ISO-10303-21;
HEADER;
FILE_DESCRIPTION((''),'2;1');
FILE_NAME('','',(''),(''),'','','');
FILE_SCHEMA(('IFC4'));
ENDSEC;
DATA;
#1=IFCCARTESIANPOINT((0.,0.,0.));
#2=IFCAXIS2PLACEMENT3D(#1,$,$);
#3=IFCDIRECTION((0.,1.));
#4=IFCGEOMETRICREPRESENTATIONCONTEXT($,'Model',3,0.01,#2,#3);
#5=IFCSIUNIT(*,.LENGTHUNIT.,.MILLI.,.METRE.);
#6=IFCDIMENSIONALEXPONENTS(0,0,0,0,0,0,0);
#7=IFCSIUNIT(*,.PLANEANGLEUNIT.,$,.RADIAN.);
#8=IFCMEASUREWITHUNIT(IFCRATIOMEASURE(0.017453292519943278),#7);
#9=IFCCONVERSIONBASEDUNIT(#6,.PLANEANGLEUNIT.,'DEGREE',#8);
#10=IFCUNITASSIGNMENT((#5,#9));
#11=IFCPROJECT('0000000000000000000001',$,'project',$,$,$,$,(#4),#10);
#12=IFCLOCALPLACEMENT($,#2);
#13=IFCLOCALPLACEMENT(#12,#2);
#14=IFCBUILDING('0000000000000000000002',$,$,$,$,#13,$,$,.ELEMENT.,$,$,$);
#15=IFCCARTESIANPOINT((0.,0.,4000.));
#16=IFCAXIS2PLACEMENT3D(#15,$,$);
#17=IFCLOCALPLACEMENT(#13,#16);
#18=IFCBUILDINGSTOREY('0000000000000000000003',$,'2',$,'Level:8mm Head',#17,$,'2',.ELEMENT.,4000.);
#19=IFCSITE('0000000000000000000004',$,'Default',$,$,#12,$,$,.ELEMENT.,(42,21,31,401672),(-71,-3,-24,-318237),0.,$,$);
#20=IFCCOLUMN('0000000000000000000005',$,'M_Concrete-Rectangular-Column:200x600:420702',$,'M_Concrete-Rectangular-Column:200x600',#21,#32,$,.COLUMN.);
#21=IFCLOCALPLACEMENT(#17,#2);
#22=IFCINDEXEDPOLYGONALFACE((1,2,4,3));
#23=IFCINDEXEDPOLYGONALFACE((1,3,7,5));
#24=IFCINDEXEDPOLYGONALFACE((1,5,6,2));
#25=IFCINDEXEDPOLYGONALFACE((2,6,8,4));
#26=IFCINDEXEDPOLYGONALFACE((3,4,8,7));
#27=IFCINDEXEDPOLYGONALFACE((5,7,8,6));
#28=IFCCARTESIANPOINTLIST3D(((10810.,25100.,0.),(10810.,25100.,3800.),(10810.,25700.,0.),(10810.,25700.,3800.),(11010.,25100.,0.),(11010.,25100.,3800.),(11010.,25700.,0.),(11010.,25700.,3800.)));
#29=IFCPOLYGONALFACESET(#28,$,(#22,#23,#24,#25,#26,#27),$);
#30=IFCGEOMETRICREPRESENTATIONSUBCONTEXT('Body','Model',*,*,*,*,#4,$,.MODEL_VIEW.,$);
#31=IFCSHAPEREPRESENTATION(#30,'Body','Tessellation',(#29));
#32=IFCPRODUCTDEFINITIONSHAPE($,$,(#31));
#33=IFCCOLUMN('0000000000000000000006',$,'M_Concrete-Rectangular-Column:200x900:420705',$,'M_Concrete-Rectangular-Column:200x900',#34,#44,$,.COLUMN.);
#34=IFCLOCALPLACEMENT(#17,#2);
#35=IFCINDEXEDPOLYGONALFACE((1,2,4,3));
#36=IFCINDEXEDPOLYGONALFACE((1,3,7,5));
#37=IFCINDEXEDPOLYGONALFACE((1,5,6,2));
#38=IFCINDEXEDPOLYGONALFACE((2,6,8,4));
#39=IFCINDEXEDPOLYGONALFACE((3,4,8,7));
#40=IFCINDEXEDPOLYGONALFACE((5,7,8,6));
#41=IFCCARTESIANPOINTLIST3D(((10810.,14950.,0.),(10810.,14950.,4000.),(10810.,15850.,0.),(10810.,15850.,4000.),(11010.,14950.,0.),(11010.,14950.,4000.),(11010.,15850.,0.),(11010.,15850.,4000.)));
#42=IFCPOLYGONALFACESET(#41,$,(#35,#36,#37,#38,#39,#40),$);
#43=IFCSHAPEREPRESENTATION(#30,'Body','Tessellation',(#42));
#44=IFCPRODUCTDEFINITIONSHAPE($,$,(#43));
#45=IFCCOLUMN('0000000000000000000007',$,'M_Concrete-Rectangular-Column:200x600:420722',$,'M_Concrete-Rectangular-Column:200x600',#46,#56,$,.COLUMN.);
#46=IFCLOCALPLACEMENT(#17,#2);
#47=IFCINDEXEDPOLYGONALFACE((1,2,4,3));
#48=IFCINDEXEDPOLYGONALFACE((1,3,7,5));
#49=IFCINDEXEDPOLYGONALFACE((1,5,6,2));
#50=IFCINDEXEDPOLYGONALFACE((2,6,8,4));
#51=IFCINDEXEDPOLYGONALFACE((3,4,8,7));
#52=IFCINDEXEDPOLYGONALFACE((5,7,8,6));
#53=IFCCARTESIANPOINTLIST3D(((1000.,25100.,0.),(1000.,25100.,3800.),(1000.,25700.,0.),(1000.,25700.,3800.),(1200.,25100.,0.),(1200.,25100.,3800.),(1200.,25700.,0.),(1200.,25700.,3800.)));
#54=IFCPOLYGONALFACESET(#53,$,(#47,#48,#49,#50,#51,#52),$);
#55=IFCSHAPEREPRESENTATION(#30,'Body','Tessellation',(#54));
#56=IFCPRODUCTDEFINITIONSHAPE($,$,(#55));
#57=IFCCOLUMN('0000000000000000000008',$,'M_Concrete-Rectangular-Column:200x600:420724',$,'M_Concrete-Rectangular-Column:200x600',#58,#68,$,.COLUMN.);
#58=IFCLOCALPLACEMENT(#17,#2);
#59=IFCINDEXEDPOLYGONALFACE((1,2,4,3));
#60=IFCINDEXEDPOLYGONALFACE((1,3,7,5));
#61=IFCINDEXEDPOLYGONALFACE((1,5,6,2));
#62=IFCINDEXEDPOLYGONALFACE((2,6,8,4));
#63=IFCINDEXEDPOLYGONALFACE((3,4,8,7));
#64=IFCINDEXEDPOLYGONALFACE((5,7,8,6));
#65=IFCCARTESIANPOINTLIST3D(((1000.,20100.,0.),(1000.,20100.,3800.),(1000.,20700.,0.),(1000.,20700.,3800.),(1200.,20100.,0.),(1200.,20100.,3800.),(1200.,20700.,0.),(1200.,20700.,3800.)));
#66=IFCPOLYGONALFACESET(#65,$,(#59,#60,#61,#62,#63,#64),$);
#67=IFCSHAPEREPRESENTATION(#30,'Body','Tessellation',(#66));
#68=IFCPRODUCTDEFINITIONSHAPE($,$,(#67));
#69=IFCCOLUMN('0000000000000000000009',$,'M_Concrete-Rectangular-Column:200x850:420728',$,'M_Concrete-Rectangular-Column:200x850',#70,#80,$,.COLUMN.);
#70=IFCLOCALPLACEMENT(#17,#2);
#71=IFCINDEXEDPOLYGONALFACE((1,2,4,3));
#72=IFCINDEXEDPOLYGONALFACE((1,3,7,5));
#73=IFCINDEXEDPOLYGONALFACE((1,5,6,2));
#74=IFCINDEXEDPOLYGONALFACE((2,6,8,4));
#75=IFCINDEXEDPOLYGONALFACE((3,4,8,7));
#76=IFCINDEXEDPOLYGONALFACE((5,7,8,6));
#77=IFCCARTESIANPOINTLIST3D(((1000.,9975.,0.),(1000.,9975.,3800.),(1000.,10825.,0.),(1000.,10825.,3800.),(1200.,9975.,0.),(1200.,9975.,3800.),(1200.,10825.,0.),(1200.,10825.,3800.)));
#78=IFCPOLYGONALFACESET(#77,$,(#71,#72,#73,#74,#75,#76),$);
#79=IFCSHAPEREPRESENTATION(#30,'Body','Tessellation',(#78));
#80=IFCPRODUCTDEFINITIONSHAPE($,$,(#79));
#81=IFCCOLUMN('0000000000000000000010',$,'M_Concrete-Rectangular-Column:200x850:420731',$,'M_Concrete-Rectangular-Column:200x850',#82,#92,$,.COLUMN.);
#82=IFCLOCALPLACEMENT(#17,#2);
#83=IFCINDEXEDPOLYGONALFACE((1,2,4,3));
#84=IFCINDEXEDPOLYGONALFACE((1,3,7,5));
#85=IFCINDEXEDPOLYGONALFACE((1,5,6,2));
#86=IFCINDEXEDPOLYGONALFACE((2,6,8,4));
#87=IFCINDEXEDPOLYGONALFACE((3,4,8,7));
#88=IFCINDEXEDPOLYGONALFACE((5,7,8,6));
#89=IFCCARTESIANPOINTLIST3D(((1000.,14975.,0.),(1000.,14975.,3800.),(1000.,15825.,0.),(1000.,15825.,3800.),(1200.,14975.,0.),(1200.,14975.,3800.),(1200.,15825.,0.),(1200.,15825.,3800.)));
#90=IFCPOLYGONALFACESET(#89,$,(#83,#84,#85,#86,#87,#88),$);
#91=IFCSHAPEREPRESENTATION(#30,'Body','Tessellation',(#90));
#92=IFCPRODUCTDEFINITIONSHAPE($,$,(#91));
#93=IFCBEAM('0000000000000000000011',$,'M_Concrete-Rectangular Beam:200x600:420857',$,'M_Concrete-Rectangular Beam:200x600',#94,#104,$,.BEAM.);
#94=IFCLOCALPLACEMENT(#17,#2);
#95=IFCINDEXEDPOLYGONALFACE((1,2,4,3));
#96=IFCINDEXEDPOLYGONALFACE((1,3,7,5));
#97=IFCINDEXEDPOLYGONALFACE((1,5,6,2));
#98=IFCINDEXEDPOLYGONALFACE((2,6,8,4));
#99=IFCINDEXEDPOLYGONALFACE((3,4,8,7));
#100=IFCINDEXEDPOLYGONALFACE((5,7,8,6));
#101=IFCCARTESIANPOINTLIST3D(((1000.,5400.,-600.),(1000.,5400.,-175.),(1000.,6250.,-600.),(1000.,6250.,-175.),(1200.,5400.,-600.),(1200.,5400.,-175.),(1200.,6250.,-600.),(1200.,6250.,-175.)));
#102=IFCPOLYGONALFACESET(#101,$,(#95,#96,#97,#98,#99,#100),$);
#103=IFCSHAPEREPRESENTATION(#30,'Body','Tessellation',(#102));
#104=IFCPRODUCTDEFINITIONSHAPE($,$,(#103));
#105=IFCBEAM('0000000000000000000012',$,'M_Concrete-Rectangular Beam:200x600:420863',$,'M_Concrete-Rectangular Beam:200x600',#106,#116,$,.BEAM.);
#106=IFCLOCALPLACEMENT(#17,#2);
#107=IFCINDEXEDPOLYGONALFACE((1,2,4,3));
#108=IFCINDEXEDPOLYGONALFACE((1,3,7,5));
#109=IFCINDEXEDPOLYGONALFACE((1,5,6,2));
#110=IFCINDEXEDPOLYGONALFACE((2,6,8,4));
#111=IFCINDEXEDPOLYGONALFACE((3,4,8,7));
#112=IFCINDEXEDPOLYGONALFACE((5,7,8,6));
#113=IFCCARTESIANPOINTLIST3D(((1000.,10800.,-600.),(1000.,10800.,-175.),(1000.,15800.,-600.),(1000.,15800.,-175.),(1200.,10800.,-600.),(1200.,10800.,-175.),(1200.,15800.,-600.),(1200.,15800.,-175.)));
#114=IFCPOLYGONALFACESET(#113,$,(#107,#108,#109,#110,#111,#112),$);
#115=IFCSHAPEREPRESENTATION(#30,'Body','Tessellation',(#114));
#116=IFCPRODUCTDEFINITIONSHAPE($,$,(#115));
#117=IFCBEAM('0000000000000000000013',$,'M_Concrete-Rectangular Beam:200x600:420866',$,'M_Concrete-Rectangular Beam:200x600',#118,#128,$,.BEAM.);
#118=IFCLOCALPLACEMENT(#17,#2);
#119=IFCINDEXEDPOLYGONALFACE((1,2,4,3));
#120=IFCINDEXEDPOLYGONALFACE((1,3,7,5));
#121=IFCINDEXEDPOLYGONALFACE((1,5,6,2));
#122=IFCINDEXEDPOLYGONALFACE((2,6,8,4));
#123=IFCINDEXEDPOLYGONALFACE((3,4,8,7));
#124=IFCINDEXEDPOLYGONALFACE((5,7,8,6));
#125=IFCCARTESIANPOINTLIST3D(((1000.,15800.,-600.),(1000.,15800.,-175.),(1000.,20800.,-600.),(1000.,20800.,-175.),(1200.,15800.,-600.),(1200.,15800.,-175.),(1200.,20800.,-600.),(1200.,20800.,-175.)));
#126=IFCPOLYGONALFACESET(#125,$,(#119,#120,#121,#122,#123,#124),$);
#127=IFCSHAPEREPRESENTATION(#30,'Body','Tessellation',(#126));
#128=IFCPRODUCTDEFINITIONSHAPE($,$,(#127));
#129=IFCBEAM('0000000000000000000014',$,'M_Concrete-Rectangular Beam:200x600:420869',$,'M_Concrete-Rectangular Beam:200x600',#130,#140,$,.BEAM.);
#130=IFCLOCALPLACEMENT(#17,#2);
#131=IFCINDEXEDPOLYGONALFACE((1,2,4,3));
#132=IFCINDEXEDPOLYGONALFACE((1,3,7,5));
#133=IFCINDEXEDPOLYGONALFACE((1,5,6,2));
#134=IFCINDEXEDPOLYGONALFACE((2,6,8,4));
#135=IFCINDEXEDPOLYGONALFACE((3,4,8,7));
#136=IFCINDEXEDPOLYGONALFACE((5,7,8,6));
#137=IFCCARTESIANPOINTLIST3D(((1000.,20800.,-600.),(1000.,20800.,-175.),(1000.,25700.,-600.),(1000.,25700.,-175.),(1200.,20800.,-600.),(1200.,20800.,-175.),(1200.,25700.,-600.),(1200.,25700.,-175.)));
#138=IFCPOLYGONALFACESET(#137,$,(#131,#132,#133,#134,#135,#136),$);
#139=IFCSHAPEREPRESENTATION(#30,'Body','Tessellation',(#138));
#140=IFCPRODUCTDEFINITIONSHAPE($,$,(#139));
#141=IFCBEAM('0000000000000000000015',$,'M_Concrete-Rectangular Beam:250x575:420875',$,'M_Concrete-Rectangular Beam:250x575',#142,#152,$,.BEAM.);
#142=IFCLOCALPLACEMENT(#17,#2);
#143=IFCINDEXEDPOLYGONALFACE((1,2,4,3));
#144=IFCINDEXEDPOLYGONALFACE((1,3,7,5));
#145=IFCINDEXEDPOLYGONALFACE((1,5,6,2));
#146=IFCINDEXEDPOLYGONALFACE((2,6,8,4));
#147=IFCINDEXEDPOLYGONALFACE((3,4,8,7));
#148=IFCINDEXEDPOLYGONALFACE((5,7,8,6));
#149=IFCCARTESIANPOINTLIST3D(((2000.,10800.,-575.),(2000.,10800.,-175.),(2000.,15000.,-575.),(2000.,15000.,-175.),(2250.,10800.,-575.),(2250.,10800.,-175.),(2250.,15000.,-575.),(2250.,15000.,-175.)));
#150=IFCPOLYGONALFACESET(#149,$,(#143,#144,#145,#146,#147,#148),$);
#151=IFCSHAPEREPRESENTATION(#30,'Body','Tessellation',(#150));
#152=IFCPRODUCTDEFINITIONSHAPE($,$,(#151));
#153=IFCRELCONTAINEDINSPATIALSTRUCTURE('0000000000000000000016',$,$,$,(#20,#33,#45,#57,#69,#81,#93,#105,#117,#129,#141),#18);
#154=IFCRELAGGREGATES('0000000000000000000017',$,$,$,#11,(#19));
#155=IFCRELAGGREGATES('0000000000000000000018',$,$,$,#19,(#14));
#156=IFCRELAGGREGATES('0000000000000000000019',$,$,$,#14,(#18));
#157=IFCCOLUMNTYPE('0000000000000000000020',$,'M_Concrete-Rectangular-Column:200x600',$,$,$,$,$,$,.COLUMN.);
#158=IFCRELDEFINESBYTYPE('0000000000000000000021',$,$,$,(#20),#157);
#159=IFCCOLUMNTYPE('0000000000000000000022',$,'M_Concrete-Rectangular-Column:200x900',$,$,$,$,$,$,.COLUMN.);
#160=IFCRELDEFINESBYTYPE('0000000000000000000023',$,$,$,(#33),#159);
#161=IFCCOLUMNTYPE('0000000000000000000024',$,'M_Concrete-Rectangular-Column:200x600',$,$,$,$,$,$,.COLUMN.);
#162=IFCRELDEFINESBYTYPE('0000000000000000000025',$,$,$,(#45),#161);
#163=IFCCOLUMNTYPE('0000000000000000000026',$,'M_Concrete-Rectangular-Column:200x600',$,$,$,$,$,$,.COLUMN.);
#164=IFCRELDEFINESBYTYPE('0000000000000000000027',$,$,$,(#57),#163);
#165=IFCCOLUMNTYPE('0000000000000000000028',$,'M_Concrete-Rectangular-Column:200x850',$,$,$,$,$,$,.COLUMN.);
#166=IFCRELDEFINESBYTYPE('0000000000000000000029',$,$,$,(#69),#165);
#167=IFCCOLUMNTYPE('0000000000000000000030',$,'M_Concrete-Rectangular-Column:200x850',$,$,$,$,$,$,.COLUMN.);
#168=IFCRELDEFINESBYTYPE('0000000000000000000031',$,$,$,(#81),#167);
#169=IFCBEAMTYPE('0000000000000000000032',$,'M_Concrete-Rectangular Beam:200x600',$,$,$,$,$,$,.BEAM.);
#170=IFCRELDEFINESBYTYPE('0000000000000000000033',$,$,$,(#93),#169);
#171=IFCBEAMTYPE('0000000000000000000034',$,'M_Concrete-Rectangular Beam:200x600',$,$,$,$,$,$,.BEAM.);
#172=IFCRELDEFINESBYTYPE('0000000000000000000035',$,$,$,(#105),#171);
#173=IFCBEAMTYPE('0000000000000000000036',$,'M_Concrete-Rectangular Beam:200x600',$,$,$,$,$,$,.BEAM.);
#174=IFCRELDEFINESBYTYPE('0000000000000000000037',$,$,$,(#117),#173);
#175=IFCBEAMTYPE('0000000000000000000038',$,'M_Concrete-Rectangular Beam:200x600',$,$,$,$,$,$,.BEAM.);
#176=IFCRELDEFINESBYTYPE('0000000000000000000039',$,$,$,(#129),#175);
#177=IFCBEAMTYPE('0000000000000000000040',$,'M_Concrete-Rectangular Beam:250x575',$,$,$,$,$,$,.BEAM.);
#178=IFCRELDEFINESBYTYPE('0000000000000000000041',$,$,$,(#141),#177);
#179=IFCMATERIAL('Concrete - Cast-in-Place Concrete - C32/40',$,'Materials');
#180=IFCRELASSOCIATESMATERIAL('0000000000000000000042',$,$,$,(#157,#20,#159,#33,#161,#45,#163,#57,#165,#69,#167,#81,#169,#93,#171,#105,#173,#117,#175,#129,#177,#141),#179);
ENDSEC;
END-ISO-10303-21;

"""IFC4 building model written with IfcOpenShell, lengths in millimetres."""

from ifc_helpers import new_model, entity, si_unit, converted_unit, direction, frame, origin, place, context, subcontext, project, spatial, indexed_curve, outline, extrude, source, transform, mapped, material, type_object, type_shapes, element, save


model = new_model("IFC4")

# Units and contexts
model_context = context("Model", 3, precision=0.01, world=origin(), true_north=direction((0.0, 1.0)))
body_context = subcontext(model_context, "Body", "Model", "MODEL_VIEW")
ifc_project = project(units=[si_unit("LENGTHUNIT", "METRE", prefix="MILLI"), converted_unit("PLANEANGLEUNIT", "DEGREE", entity("IfcRatioMeasure", 0.017453292519943278), si_unit("PLANEANGLEUNIT", "RADIAN"), dimensions=[0, 0, 0, 0, 0, 0, 0])], contexts=[model_context])

# Site, building, storey
site_placement = place(None, origin())
site = spatial("IfcSite", under=ifc_project, at=site_placement, Name="Default", CompositionType="ELEMENT", RefLatitude=(42, 21, 31, 401672), RefLongitude=(-71, -3, -24, -318237), RefElevation=0.0)
building_placement = place(site_placement, origin())
building = spatial("IfcBuilding", under=site, at=building_placement, CompositionType="ELEMENT")
storey_placement = place(building_placement, frame((0.0, 0.0, 4000.0)))
storey = spatial("IfcBuildingStorey", under=building, at=storey_placement, Name="2", ObjectType="Level:8mm Head", LongName="2", CompositionType="ELEMENT", Elevation=4000.0)

# Columns
ifc_material = material(Name="Concrete - Cast-in-Place Concrete - C32/40", Category="Materials")
column_type_1 = type_object("IfcColumnType", Name="M_Concrete-Rectangular-Column:200x600", PredefinedType="COLUMN", material=ifc_material)
shared_shape_1 = source(origin(), body_context, "Body", "SweptSolid", [
    extrude(outline(indexed_curve([(-300.0, -100.0), (300.0, -100.0), (300.0, 100.0), (-300.0, 100.0), (-300.0, -100.0)], self_intersect=False)), frame((10910.0, 25400.0, 4000.0), z_axis=(0.0, 0.0, 1.0), x_axis=(0.0, -1.0, 0.0)), (0.0, 0.0, 1.0), 3800.0),
])
type_shapes(column_type_1, [shared_shape_1])
column_1_placement = place(storey_placement, frame((0.0, 0.0, -4000.0)))
element("IfcColumn", 1, at=column_1_placement, inside=storey, type_object=column_type_1, material=ifc_material, Name="M_Concrete-Rectangular-Column:200x600:420702", ObjectType="M_Concrete-Rectangular-Column:200x600", PredefinedType="COLUMN", context=body_context, shape_type="MappedRepresentation", body=[
    mapped(shared_shape_1, transform((0.0, 0.0, 0.0), scale=1.0)),
])
column_type_2 = type_object("IfcColumnType", Name="M_Concrete-Rectangular-Column:200x900", PredefinedType="COLUMN", material=ifc_material)
shared_shape_2 = source(origin(), body_context, "Body", "SweptSolid", [
    extrude(outline(indexed_curve([(-450.0, -100.0), (450.0, -100.0), (450.0, 100.0), (-450.0, 100.0), (-450.0, -100.0)], self_intersect=False)), frame((10910.0, 15400.0, 4000.0), z_axis=(0.0, 0.0, 1.0), x_axis=(0.0, -1.0, 0.0)), (0.0, 0.0, 1.0), 4000.0),
])
type_shapes(column_type_2, [shared_shape_2])
column_2_placement = place(storey_placement, frame((0.0, 0.0, -4000.0)))
element("IfcColumn", 2, at=column_2_placement, inside=storey, type_object=column_type_2, material=ifc_material, Name="M_Concrete-Rectangular-Column:200x900:420705", ObjectType="M_Concrete-Rectangular-Column:200x900", PredefinedType="COLUMN", context=body_context, shape_type="MappedRepresentation", body=[
    mapped(shared_shape_2, transform((0.0, 0.0, 0.0), scale=1.0)),
])
column_type_3 = type_object("IfcColumnType", Name="M_Concrete-Rectangular-Column:200x600", PredefinedType="COLUMN", material=ifc_material)
shared_shape_3 = source(origin(), body_context, "Body", "SweptSolid", [
    extrude(outline(indexed_curve([(-300.0, -100.0), (300.0, -100.0), (300.0, 100.0), (-300.0, 100.0), (-300.0, -100.0)], self_intersect=False)), frame((1100.0, 25400.0, 4000.0), z_axis=(0.0, 0.0, 1.0), x_axis=(0.0, -1.0, 0.0)), (0.0, 0.0, 1.0), 3800.0),
])
type_shapes(column_type_3, [shared_shape_3])
column_3_placement = place(storey_placement, frame((0.0, 0.0, -4000.0)))
element("IfcColumn", 3, at=column_3_placement, inside=storey, type_object=column_type_3, material=ifc_material, Name="M_Concrete-Rectangular-Column:200x600:420722", ObjectType="M_Concrete-Rectangular-Column:200x600", PredefinedType="COLUMN", context=body_context, shape_type="MappedRepresentation", body=[
    mapped(shared_shape_3, transform((0.0, 0.0, 0.0), scale=1.0)),
])
column_type_4 = type_object("IfcColumnType", Name="M_Concrete-Rectangular-Column:200x600", PredefinedType="COLUMN", material=ifc_material)
shared_shape_4 = source(origin(), body_context, "Body", "SweptSolid", [
    extrude(outline(indexed_curve([(-300.0, -100.0), (300.0, -100.0), (300.0, 100.0), (-300.0, 100.0), (-300.0, -100.0)], self_intersect=False)), frame((1100.0, 20400.0, 4000.0), z_axis=(0.0, 0.0, 1.0), x_axis=(0.0, -1.0, 0.0)), (0.0, 0.0, 1.0), 3800.0),
])
type_shapes(column_type_4, [shared_shape_4])
column_4_placement = place(storey_placement, frame((0.0, 0.0, -4000.0)))
element("IfcColumn", 4, at=column_4_placement, inside=storey, type_object=column_type_4, material=ifc_material, Name="M_Concrete-Rectangular-Column:200x600:420724", ObjectType="M_Concrete-Rectangular-Column:200x600", PredefinedType="COLUMN", context=body_context, shape_type="MappedRepresentation", body=[
    mapped(shared_shape_4, transform((0.0, 0.0, 0.0), scale=1.0)),
])
column_type_5 = type_object("IfcColumnType", Name="M_Concrete-Rectangular-Column:200x850", PredefinedType="COLUMN", material=ifc_material)
shared_shape_5 = source(origin(), body_context, "Body", "SweptSolid", [
    extrude(outline(indexed_curve([(-425.0, -100.0), (425.0, -100.0), (425.0, 100.0), (-425.0, 100.0), (-425.0, -100.0)], self_intersect=False)), frame((1100.0, 10400.0, 4000.0), z_axis=(0.0, 0.0, 1.0), x_axis=(0.0, -1.0, 0.0)), (0.0, 0.0, 1.0), 3800.0),
])
type_shapes(column_type_5, [shared_shape_5])
column_5_placement = place(storey_placement, frame((0.0, 0.0, -4000.0)))
element("IfcColumn", 5, at=column_5_placement, inside=storey, type_object=column_type_5, material=ifc_material, Name="M_Concrete-Rectangular-Column:200x850:420728", ObjectType="M_Concrete-Rectangular-Column:200x850", PredefinedType="COLUMN", context=body_context, shape_type="MappedRepresentation", body=[
    mapped(shared_shape_5, transform((0.0, 0.0, 0.0), scale=1.0)),
])
column_type_6 = type_object("IfcColumnType", Name="M_Concrete-Rectangular-Column:200x850", PredefinedType="COLUMN", material=ifc_material)
shared_shape_6 = source(origin(), body_context, "Body", "SweptSolid", [
    extrude(outline(indexed_curve([(-425.0, -100.0), (425.0, -100.0), (425.0, 100.0), (-425.0, 100.0), (-425.0, -100.0)], self_intersect=False)), frame((1100.0, 15400.0, 4000.0), z_axis=(0.0, 0.0, 1.0), x_axis=(0.0, -1.0, 0.0)), (0.0, 0.0, 1.0), 3800.0),
])
type_shapes(column_type_6, [shared_shape_6])
column_6_placement = place(storey_placement, frame((0.0, 0.0, -4000.0)))
element("IfcColumn", 6, at=column_6_placement, inside=storey, type_object=column_type_6, material=ifc_material, Name="M_Concrete-Rectangular-Column:200x850:420731", ObjectType="M_Concrete-Rectangular-Column:200x850", PredefinedType="COLUMN", context=body_context, shape_type="MappedRepresentation", body=[
    mapped(shared_shape_6, transform((0.0, 0.0, 0.0), scale=1.0)),
])

# Beams
beam_type_1 = type_object("IfcBeamType", Name="M_Concrete-Rectangular Beam:200x600", PredefinedType="BEAM", material=ifc_material)
shared_shape_7 = source(origin(), body_context, "Body", "SweptSolid", [
    extrude(outline(indexed_curve([(-100.0, -212.5), (100.0, -212.5), (100.0, 212.5), (-100.0, 212.5), (-100.0, -212.5)], self_intersect=False)), frame((1100.0, 5400.0, 3612.5), z_axis=(0.0, 1.0, 0.0), x_axis=(-1.0, 0.0, 0.0)), (0.0, 0.0, 1.0), 850.0),
])
type_shapes(beam_type_1, [shared_shape_7])
beam_1_placement = place(storey_placement, frame((0.0, 0.0, -4000.0)))
element("IfcBeam", 7, at=beam_1_placement, inside=storey, type_object=beam_type_1, material=ifc_material, Name="M_Concrete-Rectangular Beam:200x600:420857", ObjectType="M_Concrete-Rectangular Beam:200x600", PredefinedType="BEAM", context=body_context, shape_type="MappedRepresentation", body=[
    mapped(shared_shape_7, transform((0.0, 0.0, 0.0), scale=1.0)),
])
beam_type_2 = type_object("IfcBeamType", Name="M_Concrete-Rectangular Beam:200x600", PredefinedType="BEAM", material=ifc_material)
shared_shape_8 = source(origin(), body_context, "Body", "SweptSolid", [
    extrude(outline(indexed_curve([(-100.0, -212.5), (100.0, -212.5), (100.0, 212.5), (-100.0, 212.5), (-100.0, -212.5)], self_intersect=False)), frame((1100.0, 10800.0, 3612.5), z_axis=(0.0, 1.0, 0.0), x_axis=(-1.0, 0.0, 0.0)), (0.0, 0.0, 1.0), 5000.0),
])
type_shapes(beam_type_2, [shared_shape_8])
beam_2_placement = place(storey_placement, frame((0.0, 0.0, -4000.0)))
element("IfcBeam", 8, at=beam_2_placement, inside=storey, type_object=beam_type_2, material=ifc_material, Name="M_Concrete-Rectangular Beam:200x600:420863", ObjectType="M_Concrete-Rectangular Beam:200x600", PredefinedType="BEAM", context=body_context, shape_type="MappedRepresentation", body=[
    mapped(shared_shape_8, transform((0.0, 0.0, 0.0), scale=1.0)),
])
beam_type_3 = type_object("IfcBeamType", Name="M_Concrete-Rectangular Beam:200x600", PredefinedType="BEAM", material=ifc_material)
shared_shape_9 = source(origin(), body_context, "Body", "SweptSolid", [
    extrude(outline(indexed_curve([(-100.0, -212.5), (100.0, -212.5), (100.0, 212.5), (-100.0, 212.5), (-100.0, -212.5)], self_intersect=False)), frame((1100.0, 15800.0, 3612.5), z_axis=(0.0, 1.0, 0.0), x_axis=(-1.0, 0.0, 0.0)), (0.0, 0.0, 1.0), 5000.0),
])
type_shapes(beam_type_3, [shared_shape_9])
beam_3_placement = place(storey_placement, frame((0.0, 0.0, -4000.0)))
element("IfcBeam", 9, at=beam_3_placement, inside=storey, type_object=beam_type_3, material=ifc_material, Name="M_Concrete-Rectangular Beam:200x600:420866", ObjectType="M_Concrete-Rectangular Beam:200x600", PredefinedType="BEAM", context=body_context, shape_type="MappedRepresentation", body=[
    mapped(shared_shape_9, transform((0.0, 0.0, 0.0), scale=1.0)),
])
beam_type_4 = type_object("IfcBeamType", Name="M_Concrete-Rectangular Beam:200x600", PredefinedType="BEAM", material=ifc_material)
shared_shape_10 = source(origin(), body_context, "Body", "SweptSolid", [
    extrude(outline(indexed_curve([(-100.0, -212.5), (100.0, -212.5), (100.0, 212.5), (-100.0, 212.5), (-100.0, -212.5)], self_intersect=False)), frame((1100.0, 20800.0, 3612.5), z_axis=(0.0, 1.0, 0.0), x_axis=(-1.0, 0.0, 0.0)), (0.0, 0.0, 1.0), 4900.0),
])
type_shapes(beam_type_4, [shared_shape_10])
beam_4_placement = place(storey_placement, frame((0.0, 0.0, -4000.0)))
element("IfcBeam", 10, at=beam_4_placement, inside=storey, type_object=beam_type_4, material=ifc_material, Name="M_Concrete-Rectangular Beam:200x600:420869", ObjectType="M_Concrete-Rectangular Beam:200x600", PredefinedType="BEAM", context=body_context, shape_type="MappedRepresentation", body=[
    mapped(shared_shape_10, transform((0.0, 0.0, 0.0), scale=1.0)),
])
beam_type_5 = type_object("IfcBeamType", Name="M_Concrete-Rectangular Beam:250x575", PredefinedType="BEAM", material=ifc_material)
shared_shape_11 = source(origin(), body_context, "Body", "SweptSolid", [
    extrude(outline(indexed_curve([(-125.0, -200.0), (125.0, -200.0), (125.0, 200.0), (-125.0, 200.0), (-125.0, -200.0)], self_intersect=False)), frame((2125.0, 10800.0, 3625.0), z_axis=(0.0, 1.0, 0.0), x_axis=(-1.0, 0.0, 0.0)), (0.0, 0.0, 1.0), 4200.0),
])
type_shapes(beam_type_5, [shared_shape_11])
beam_5_placement = place(storey_placement, frame((0.0, 0.0, -4000.0)))
element("IfcBeam", 11, at=beam_5_placement, inside=storey, type_object=beam_type_5, material=ifc_material, Name="M_Concrete-Rectangular Beam:250x575:420875", ObjectType="M_Concrete-Rectangular Beam:250x575", PredefinedType="BEAM", context=body_context, shape_type="MappedRepresentation", body=[
    mapped(shared_shape_11, transform((0.0, 0.0, 0.0), scale=1.0)),
])

save(model, "model.ifc")
